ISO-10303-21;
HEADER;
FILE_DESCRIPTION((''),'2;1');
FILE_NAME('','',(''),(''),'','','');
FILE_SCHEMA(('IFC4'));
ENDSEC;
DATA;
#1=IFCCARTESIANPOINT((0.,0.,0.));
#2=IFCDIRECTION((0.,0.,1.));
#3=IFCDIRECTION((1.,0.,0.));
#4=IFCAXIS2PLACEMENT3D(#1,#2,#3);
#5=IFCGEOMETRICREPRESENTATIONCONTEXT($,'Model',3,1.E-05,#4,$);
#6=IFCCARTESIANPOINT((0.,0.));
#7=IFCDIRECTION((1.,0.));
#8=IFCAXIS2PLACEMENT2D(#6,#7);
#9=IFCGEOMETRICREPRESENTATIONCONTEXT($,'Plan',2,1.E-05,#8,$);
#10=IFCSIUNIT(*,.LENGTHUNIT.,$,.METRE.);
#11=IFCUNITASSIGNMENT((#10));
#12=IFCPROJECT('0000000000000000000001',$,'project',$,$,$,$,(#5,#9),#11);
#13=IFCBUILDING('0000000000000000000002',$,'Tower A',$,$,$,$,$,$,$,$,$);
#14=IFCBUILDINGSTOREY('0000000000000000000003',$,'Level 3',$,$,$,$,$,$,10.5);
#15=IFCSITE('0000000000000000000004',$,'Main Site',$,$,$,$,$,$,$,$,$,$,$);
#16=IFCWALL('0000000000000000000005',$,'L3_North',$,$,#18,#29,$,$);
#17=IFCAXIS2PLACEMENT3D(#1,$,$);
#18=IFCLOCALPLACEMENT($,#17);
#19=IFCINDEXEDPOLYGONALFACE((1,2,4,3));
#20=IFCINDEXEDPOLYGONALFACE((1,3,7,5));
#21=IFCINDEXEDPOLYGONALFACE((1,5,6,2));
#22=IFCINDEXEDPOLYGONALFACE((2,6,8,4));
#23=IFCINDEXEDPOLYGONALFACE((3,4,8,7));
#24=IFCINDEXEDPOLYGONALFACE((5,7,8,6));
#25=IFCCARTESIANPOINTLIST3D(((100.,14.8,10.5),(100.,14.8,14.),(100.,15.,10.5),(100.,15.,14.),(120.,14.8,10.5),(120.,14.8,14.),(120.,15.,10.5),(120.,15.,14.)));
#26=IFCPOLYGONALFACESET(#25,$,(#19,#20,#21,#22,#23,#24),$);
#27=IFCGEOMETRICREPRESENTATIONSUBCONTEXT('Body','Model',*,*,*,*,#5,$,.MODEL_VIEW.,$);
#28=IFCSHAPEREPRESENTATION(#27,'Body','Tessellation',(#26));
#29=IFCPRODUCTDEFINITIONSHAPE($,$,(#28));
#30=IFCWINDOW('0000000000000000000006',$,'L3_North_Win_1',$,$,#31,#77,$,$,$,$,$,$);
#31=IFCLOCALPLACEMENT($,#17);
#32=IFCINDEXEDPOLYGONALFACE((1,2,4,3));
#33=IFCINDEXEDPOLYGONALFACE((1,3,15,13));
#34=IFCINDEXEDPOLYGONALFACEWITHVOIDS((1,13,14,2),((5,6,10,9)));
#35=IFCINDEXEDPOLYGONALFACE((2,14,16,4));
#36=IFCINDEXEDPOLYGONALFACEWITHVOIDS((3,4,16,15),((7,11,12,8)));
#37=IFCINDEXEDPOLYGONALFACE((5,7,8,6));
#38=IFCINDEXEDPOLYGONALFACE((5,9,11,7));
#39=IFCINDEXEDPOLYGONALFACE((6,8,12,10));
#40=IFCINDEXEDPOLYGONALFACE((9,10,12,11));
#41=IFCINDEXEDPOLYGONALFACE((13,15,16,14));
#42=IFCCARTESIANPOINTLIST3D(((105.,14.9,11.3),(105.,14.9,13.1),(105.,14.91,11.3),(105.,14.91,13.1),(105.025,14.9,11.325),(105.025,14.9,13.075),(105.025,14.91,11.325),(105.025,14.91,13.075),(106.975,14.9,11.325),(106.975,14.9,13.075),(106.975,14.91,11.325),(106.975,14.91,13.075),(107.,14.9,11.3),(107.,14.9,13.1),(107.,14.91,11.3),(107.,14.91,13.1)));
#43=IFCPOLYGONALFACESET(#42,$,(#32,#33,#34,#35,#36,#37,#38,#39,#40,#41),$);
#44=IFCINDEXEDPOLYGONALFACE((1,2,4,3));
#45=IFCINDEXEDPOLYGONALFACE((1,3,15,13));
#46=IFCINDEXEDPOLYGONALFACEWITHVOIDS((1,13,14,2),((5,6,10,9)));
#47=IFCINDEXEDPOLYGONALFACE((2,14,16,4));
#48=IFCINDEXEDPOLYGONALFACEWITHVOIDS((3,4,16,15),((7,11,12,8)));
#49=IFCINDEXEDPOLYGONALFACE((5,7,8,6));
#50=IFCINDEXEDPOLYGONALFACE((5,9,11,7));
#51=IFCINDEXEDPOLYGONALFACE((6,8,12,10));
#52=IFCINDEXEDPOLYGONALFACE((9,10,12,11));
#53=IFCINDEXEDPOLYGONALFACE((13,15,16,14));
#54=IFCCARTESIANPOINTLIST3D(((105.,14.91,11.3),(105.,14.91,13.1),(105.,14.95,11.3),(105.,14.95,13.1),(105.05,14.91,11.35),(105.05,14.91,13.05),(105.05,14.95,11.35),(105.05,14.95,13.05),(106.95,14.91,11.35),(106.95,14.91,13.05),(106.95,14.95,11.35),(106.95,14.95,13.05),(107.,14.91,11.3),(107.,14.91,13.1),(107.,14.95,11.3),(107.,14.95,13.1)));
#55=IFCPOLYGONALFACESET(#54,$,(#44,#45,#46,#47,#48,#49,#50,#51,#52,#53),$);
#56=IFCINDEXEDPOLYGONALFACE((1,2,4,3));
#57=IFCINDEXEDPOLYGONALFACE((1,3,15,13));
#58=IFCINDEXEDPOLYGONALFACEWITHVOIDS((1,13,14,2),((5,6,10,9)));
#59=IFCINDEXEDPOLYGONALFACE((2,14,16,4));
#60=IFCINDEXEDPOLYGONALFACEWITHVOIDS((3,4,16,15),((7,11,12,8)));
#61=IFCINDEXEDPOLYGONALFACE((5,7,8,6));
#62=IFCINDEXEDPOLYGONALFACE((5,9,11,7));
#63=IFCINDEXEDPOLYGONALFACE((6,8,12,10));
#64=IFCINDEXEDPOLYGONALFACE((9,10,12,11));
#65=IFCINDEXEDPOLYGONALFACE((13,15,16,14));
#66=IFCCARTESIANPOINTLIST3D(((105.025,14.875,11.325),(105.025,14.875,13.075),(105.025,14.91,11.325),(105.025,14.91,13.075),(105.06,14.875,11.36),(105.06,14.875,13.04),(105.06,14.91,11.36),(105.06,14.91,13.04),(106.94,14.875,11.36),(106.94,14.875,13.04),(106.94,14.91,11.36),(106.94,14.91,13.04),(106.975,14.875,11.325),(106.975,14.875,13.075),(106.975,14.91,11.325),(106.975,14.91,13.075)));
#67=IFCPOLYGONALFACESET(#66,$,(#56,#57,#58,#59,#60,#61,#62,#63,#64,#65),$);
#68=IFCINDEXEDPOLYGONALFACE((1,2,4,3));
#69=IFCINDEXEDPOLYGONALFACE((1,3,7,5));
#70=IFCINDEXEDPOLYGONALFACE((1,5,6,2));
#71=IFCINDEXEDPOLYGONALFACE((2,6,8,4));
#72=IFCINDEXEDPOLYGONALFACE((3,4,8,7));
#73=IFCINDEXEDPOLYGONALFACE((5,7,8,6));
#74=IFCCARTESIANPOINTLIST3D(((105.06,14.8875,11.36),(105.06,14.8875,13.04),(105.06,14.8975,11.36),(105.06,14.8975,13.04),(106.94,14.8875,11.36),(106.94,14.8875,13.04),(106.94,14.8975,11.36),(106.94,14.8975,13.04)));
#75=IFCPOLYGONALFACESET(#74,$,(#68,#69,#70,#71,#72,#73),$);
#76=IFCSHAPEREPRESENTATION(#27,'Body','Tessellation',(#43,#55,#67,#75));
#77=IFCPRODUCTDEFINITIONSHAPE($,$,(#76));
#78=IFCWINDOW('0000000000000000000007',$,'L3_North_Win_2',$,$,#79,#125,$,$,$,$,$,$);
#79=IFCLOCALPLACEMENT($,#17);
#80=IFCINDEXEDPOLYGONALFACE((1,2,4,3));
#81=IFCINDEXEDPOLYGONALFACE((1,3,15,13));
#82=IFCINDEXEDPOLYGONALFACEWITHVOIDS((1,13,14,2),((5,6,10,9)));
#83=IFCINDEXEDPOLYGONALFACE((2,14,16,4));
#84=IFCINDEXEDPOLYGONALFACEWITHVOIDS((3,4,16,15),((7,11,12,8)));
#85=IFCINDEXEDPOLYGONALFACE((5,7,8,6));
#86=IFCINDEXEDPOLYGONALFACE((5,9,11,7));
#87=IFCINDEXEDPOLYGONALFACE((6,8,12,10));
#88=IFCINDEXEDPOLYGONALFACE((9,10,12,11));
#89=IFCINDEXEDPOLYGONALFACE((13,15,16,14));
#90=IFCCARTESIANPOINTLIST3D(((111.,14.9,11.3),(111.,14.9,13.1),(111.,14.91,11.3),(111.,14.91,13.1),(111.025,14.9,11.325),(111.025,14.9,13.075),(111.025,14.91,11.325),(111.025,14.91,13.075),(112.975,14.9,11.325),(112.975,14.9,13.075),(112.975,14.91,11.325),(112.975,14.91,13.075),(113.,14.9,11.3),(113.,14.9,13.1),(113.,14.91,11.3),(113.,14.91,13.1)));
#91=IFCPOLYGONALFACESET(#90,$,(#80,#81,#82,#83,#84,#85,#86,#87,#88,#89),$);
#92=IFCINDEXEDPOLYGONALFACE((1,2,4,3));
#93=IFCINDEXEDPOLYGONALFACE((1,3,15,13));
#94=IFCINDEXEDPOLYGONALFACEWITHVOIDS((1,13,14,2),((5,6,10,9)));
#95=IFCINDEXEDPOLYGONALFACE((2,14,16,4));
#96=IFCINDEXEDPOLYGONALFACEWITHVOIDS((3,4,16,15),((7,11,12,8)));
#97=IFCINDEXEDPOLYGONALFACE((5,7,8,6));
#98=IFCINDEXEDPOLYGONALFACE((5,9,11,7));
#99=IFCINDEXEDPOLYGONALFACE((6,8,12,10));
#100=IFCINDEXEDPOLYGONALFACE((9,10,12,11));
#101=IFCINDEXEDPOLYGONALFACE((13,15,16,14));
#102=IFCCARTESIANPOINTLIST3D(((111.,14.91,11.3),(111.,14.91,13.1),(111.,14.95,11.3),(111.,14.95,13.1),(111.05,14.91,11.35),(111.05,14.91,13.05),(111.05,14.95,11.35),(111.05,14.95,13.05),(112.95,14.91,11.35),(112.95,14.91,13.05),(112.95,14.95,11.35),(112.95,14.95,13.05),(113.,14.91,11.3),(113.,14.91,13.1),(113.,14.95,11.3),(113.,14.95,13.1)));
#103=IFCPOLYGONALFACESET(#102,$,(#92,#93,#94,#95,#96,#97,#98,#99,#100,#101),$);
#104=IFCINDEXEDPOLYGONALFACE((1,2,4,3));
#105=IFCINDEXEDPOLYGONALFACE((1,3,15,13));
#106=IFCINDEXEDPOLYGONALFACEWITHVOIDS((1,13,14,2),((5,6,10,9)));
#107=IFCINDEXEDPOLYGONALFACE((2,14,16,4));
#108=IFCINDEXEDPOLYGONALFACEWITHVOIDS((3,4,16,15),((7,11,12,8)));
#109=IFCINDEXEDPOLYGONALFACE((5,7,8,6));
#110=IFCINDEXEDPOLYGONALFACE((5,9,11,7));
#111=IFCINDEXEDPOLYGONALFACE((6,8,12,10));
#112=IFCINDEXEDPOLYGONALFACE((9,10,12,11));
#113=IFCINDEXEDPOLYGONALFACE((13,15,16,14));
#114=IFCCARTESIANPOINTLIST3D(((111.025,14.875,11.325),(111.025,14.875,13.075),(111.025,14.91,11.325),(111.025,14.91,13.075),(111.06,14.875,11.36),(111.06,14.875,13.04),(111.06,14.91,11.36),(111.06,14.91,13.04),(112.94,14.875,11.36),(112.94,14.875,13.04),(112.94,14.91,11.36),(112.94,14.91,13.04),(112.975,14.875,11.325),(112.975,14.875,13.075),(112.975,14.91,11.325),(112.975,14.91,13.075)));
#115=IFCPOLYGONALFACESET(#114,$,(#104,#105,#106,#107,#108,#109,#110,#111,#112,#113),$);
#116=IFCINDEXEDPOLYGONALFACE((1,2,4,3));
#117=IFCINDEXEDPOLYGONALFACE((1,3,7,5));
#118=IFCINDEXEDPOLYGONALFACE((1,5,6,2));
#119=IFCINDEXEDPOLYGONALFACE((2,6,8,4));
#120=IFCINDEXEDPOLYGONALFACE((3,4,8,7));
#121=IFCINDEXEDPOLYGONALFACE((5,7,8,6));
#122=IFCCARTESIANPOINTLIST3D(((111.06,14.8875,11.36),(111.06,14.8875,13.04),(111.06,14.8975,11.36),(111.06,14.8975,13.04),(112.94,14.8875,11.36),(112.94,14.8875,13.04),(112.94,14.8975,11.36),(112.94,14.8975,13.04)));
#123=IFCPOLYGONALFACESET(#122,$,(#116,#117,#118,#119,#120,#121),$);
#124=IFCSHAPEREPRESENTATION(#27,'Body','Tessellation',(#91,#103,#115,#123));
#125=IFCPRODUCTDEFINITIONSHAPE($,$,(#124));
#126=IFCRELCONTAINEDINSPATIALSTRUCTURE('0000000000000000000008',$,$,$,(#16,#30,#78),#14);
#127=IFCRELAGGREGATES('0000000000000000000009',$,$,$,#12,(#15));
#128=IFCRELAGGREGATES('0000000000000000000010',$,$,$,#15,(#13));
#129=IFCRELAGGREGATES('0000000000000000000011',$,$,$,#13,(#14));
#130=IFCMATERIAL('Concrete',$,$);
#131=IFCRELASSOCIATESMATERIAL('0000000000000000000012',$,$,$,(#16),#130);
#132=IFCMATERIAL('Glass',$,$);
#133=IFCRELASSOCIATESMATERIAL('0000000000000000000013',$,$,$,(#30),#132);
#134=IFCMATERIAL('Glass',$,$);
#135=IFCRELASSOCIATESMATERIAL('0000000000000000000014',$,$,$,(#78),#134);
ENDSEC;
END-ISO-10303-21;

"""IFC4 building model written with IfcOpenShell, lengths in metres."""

from ifc_helpers import new_model, si_unit, frame, origin_with_axes, origin_2d_with_axis, place, context, subcontext, project, spatial, line, indexed_curve, outline, extrude, material, element, fill, save


model = new_model("IFC4")

# Units and contexts
model_context = context("Model", 3, precision=1e-05, world=origin_with_axes())
plan_context = context("Plan", 2, precision=1e-05, world=origin_2d_with_axis())
body_context = subcontext(model_context, "Body", "Model", "MODEL_VIEW")
ifc_project = project(units=[si_unit("LENGTHUNIT", "METRE")], contexts=[model_context, plan_context])

# Site, building, storey
site = spatial("IfcSite", under=ifc_project, Name="Main Site")
building = spatial("IfcBuilding", under=site, Name="Tower A")
storey = spatial("IfcBuildingStorey", under=building, Name="Level 3", Elevation=10.5)

# Wall, openings, windows
ifc_material_1 = material(Name="Concrete")
wall_1_placement = place(None, frame((120.0, 15.0, 10.5), z_axis=(0.0, 0.0, 1.0), x_axis=(-1.0, 0.0, 0.0)))
wall_1 = element("IfcWall", 1, at=wall_1_placement, inside=storey, material=ifc_material_1, Name="L3_North", context=body_context, shape_type="SweptSolid", body=[
    extrude(outline(indexed_curve([(0.0, 0.0), (0.0, 0.2), (20.0, 0.2), (20.0, 0.0), (0.0, 0.0)], self_intersect=False)), origin_with_axes(), (0.0, 0.0, 1.0), 3.5),
])
opening_1_placement = place(wall_1_placement, frame((13.0, 0.0, 0.8), z_axis=(0.0, 0.0, 1.0), x_axis=(-1.0, 0.0, 0.0)))
opening_1 = element("IfcOpeningElement", 2, at=opening_1_placement, cuts=wall_1, context=body_context, shape_type="SweptSolid", body=[
    extrude(outline(indexed_curve([(0.0, 0.0), (0.0, 0.25), (2.0, 0.25), (2.0, 0.0), (0.0, 0.0)], self_intersect=False)), origin_with_axes(), (0.0, 0.0, 1.0), 1.8),
])
opening_2_placement = place(wall_1_placement, frame((7.0, 0.0, 0.8), z_axis=(0.0, 0.0, 1.0), x_axis=(-1.0, 0.0, 0.0)))
opening_2 = element("IfcOpeningElement", 3, at=opening_2_placement, cuts=wall_1, context=body_context, shape_type="SweptSolid", body=[
    extrude(outline(indexed_curve([(0.0, 0.0), (0.0, 0.25), (2.0, 0.25), (2.0, 0.0), (0.0, 0.0)], self_intersect=False)), origin_with_axes(), (0.0, 0.0, 1.0), 1.8),
])
ifc_material_2 = material(Name="Glass")
window_1_placement = place(None, frame((107.0, 15.0, 11.3), z_axis=(0.0, 0.0, 1.0), x_axis=(-1.0, 0.0, 0.0)))
window_1 = element("IfcWindow", 4, at=window_1_placement, inside=storey, material=ifc_material_2, Name="L3_North_Win_1", context=body_context, shape_type="SweptSolid", body=[
    extrude(outline(indexed_curve([(0.0, 0.0), (2.0, 0.0), (2.0, 1.8), (0.0, 1.8)], segments=[line(1, 2, 3, 4, 1)]), holes=[indexed_curve([(0.025, 0.025), (1.975, 0.025), (1.975, 1.775), (0.025, 1.775)], segments=[line(1, 2, 3, 4, 1)])]), frame((0.0, 0.09, 0.0), z_axis=(0.0, -1.0, 0.0), x_axis=(1.0, 0.0, 0.0)), (0.0, 0.0, -1.0), 0.01),
    extrude(outline(indexed_curve([(0.0, 0.0), (2.0, 0.0), (2.0, 1.8), (0.0, 1.8)], segments=[line(1, 2, 3, 4, 1)]), holes=[indexed_curve([(0.05, 0.05), (1.95, 0.05), (1.95, 1.75), (0.05, 1.75)], segments=[line(1, 2, 3, 4, 1)])]), frame((0.0, 0.05, 0.0), z_axis=(0.0, -1.0, 0.0), x_axis=(1.0, 0.0, 0.0)), (0.0, 0.0, -1.0), 0.04),
    extrude(outline(indexed_curve([(0.0, 0.0), (1.95, 0.0), (1.95, 1.75), (0.0, 1.75)], segments=[line(1, 2, 3, 4, 1)]), holes=[indexed_curve([(0.035, 0.035), (1.915, 0.035), (1.915, 1.715), (0.035, 1.715)], segments=[line(1, 2, 3, 4, 1)])]), frame((0.025, 0.09, 0.025), z_axis=(0.0, -1.0, 0.0), x_axis=(1.0, 0.0, 0.0)), (0.0, 0.0, -1.0), 0.035),
    extrude(outline(indexed_curve([(0.035, 0.035), (1.915, 0.035), (1.915, 1.715), (0.035, 1.715)], segments=[line(1, 2, 3, 4, 1)])), frame((0.025, 0.1025, 0.025), z_axis=(0.0, -1.0, 0.0), x_axis=(1.0, 0.0, 0.0)), (0.0, 0.0, -1.0), 0.01),
])
fill(opening_1, window_1)
ifc_material_3 = material(Name="Glass")
window_2_placement = place(None, frame((113.0, 15.0, 11.3), z_axis=(0.0, 0.0, 1.0), x_axis=(-1.0, 0.0, 0.0)))
window_2 = element("IfcWindow", 5, at=window_2_placement, inside=storey, material=ifc_material_3, Name="L3_North_Win_2", context=body_context, shape_type="SweptSolid", body=[
    extrude(outline(indexed_curve([(0.0, 0.0), (2.0, 0.0), (2.0, 1.8), (0.0, 1.8)], segments=[line(1, 2, 3, 4, 1)]), holes=[indexed_curve([(0.025, 0.025), (1.975, 0.025), (1.975, 1.775), (0.025, 1.775)], segments=[line(1, 2, 3, 4, 1)])]), frame((0.0, 0.09, 0.0), z_axis=(0.0, -1.0, 0.0), x_axis=(1.0, 0.0, 0.0)), (0.0, 0.0, -1.0), 0.01),
    extrude(outline(indexed_curve([(0.0, 0.0), (2.0, 0.0), (2.0, 1.8), (0.0, 1.8)], segments=[line(1, 2, 3, 4, 1)]), holes=[indexed_curve([(0.05, 0.05), (1.95, 0.05), (1.95, 1.75), (0.05, 1.75)], segments=[line(1, 2, 3, 4, 1)])]), frame((0.0, 0.05, 0.0), z_axis=(0.0, -1.0, 0.0), x_axis=(1.0, 0.0, 0.0)), (0.0, 0.0, -1.0), 0.04),
    extrude(outline(indexed_curve([(0.0, 0.0), (1.95, 0.0), (1.95, 1.75), (0.0, 1.75)], segments=[line(1, 2, 3, 4, 1)]), holes=[indexed_curve([(0.035, 0.035), (1.915, 0.035), (1.915, 1.715), (0.035, 1.715)], segments=[line(1, 2, 3, 4, 1)])]), frame((0.025, 0.09, 0.025), z_axis=(0.0, -1.0, 0.0), x_axis=(1.0, 0.0, 0.0)), (0.0, 0.0, -1.0), 0.035),
    extrude(outline(indexed_curve([(0.035, 0.035), (1.915, 0.035), (1.915, 1.715), (0.035, 1.715)], segments=[line(1, 2, 3, 4, 1)])), frame((0.025, 0.1025, 0.025), z_axis=(0.0, -1.0, 0.0), x_axis=(1.0, 0.0, 0.0)), (0.0, 0.0, -1.0), 0.01),
])
fill(opening_2, window_2)

save(model, "model.ifc")
